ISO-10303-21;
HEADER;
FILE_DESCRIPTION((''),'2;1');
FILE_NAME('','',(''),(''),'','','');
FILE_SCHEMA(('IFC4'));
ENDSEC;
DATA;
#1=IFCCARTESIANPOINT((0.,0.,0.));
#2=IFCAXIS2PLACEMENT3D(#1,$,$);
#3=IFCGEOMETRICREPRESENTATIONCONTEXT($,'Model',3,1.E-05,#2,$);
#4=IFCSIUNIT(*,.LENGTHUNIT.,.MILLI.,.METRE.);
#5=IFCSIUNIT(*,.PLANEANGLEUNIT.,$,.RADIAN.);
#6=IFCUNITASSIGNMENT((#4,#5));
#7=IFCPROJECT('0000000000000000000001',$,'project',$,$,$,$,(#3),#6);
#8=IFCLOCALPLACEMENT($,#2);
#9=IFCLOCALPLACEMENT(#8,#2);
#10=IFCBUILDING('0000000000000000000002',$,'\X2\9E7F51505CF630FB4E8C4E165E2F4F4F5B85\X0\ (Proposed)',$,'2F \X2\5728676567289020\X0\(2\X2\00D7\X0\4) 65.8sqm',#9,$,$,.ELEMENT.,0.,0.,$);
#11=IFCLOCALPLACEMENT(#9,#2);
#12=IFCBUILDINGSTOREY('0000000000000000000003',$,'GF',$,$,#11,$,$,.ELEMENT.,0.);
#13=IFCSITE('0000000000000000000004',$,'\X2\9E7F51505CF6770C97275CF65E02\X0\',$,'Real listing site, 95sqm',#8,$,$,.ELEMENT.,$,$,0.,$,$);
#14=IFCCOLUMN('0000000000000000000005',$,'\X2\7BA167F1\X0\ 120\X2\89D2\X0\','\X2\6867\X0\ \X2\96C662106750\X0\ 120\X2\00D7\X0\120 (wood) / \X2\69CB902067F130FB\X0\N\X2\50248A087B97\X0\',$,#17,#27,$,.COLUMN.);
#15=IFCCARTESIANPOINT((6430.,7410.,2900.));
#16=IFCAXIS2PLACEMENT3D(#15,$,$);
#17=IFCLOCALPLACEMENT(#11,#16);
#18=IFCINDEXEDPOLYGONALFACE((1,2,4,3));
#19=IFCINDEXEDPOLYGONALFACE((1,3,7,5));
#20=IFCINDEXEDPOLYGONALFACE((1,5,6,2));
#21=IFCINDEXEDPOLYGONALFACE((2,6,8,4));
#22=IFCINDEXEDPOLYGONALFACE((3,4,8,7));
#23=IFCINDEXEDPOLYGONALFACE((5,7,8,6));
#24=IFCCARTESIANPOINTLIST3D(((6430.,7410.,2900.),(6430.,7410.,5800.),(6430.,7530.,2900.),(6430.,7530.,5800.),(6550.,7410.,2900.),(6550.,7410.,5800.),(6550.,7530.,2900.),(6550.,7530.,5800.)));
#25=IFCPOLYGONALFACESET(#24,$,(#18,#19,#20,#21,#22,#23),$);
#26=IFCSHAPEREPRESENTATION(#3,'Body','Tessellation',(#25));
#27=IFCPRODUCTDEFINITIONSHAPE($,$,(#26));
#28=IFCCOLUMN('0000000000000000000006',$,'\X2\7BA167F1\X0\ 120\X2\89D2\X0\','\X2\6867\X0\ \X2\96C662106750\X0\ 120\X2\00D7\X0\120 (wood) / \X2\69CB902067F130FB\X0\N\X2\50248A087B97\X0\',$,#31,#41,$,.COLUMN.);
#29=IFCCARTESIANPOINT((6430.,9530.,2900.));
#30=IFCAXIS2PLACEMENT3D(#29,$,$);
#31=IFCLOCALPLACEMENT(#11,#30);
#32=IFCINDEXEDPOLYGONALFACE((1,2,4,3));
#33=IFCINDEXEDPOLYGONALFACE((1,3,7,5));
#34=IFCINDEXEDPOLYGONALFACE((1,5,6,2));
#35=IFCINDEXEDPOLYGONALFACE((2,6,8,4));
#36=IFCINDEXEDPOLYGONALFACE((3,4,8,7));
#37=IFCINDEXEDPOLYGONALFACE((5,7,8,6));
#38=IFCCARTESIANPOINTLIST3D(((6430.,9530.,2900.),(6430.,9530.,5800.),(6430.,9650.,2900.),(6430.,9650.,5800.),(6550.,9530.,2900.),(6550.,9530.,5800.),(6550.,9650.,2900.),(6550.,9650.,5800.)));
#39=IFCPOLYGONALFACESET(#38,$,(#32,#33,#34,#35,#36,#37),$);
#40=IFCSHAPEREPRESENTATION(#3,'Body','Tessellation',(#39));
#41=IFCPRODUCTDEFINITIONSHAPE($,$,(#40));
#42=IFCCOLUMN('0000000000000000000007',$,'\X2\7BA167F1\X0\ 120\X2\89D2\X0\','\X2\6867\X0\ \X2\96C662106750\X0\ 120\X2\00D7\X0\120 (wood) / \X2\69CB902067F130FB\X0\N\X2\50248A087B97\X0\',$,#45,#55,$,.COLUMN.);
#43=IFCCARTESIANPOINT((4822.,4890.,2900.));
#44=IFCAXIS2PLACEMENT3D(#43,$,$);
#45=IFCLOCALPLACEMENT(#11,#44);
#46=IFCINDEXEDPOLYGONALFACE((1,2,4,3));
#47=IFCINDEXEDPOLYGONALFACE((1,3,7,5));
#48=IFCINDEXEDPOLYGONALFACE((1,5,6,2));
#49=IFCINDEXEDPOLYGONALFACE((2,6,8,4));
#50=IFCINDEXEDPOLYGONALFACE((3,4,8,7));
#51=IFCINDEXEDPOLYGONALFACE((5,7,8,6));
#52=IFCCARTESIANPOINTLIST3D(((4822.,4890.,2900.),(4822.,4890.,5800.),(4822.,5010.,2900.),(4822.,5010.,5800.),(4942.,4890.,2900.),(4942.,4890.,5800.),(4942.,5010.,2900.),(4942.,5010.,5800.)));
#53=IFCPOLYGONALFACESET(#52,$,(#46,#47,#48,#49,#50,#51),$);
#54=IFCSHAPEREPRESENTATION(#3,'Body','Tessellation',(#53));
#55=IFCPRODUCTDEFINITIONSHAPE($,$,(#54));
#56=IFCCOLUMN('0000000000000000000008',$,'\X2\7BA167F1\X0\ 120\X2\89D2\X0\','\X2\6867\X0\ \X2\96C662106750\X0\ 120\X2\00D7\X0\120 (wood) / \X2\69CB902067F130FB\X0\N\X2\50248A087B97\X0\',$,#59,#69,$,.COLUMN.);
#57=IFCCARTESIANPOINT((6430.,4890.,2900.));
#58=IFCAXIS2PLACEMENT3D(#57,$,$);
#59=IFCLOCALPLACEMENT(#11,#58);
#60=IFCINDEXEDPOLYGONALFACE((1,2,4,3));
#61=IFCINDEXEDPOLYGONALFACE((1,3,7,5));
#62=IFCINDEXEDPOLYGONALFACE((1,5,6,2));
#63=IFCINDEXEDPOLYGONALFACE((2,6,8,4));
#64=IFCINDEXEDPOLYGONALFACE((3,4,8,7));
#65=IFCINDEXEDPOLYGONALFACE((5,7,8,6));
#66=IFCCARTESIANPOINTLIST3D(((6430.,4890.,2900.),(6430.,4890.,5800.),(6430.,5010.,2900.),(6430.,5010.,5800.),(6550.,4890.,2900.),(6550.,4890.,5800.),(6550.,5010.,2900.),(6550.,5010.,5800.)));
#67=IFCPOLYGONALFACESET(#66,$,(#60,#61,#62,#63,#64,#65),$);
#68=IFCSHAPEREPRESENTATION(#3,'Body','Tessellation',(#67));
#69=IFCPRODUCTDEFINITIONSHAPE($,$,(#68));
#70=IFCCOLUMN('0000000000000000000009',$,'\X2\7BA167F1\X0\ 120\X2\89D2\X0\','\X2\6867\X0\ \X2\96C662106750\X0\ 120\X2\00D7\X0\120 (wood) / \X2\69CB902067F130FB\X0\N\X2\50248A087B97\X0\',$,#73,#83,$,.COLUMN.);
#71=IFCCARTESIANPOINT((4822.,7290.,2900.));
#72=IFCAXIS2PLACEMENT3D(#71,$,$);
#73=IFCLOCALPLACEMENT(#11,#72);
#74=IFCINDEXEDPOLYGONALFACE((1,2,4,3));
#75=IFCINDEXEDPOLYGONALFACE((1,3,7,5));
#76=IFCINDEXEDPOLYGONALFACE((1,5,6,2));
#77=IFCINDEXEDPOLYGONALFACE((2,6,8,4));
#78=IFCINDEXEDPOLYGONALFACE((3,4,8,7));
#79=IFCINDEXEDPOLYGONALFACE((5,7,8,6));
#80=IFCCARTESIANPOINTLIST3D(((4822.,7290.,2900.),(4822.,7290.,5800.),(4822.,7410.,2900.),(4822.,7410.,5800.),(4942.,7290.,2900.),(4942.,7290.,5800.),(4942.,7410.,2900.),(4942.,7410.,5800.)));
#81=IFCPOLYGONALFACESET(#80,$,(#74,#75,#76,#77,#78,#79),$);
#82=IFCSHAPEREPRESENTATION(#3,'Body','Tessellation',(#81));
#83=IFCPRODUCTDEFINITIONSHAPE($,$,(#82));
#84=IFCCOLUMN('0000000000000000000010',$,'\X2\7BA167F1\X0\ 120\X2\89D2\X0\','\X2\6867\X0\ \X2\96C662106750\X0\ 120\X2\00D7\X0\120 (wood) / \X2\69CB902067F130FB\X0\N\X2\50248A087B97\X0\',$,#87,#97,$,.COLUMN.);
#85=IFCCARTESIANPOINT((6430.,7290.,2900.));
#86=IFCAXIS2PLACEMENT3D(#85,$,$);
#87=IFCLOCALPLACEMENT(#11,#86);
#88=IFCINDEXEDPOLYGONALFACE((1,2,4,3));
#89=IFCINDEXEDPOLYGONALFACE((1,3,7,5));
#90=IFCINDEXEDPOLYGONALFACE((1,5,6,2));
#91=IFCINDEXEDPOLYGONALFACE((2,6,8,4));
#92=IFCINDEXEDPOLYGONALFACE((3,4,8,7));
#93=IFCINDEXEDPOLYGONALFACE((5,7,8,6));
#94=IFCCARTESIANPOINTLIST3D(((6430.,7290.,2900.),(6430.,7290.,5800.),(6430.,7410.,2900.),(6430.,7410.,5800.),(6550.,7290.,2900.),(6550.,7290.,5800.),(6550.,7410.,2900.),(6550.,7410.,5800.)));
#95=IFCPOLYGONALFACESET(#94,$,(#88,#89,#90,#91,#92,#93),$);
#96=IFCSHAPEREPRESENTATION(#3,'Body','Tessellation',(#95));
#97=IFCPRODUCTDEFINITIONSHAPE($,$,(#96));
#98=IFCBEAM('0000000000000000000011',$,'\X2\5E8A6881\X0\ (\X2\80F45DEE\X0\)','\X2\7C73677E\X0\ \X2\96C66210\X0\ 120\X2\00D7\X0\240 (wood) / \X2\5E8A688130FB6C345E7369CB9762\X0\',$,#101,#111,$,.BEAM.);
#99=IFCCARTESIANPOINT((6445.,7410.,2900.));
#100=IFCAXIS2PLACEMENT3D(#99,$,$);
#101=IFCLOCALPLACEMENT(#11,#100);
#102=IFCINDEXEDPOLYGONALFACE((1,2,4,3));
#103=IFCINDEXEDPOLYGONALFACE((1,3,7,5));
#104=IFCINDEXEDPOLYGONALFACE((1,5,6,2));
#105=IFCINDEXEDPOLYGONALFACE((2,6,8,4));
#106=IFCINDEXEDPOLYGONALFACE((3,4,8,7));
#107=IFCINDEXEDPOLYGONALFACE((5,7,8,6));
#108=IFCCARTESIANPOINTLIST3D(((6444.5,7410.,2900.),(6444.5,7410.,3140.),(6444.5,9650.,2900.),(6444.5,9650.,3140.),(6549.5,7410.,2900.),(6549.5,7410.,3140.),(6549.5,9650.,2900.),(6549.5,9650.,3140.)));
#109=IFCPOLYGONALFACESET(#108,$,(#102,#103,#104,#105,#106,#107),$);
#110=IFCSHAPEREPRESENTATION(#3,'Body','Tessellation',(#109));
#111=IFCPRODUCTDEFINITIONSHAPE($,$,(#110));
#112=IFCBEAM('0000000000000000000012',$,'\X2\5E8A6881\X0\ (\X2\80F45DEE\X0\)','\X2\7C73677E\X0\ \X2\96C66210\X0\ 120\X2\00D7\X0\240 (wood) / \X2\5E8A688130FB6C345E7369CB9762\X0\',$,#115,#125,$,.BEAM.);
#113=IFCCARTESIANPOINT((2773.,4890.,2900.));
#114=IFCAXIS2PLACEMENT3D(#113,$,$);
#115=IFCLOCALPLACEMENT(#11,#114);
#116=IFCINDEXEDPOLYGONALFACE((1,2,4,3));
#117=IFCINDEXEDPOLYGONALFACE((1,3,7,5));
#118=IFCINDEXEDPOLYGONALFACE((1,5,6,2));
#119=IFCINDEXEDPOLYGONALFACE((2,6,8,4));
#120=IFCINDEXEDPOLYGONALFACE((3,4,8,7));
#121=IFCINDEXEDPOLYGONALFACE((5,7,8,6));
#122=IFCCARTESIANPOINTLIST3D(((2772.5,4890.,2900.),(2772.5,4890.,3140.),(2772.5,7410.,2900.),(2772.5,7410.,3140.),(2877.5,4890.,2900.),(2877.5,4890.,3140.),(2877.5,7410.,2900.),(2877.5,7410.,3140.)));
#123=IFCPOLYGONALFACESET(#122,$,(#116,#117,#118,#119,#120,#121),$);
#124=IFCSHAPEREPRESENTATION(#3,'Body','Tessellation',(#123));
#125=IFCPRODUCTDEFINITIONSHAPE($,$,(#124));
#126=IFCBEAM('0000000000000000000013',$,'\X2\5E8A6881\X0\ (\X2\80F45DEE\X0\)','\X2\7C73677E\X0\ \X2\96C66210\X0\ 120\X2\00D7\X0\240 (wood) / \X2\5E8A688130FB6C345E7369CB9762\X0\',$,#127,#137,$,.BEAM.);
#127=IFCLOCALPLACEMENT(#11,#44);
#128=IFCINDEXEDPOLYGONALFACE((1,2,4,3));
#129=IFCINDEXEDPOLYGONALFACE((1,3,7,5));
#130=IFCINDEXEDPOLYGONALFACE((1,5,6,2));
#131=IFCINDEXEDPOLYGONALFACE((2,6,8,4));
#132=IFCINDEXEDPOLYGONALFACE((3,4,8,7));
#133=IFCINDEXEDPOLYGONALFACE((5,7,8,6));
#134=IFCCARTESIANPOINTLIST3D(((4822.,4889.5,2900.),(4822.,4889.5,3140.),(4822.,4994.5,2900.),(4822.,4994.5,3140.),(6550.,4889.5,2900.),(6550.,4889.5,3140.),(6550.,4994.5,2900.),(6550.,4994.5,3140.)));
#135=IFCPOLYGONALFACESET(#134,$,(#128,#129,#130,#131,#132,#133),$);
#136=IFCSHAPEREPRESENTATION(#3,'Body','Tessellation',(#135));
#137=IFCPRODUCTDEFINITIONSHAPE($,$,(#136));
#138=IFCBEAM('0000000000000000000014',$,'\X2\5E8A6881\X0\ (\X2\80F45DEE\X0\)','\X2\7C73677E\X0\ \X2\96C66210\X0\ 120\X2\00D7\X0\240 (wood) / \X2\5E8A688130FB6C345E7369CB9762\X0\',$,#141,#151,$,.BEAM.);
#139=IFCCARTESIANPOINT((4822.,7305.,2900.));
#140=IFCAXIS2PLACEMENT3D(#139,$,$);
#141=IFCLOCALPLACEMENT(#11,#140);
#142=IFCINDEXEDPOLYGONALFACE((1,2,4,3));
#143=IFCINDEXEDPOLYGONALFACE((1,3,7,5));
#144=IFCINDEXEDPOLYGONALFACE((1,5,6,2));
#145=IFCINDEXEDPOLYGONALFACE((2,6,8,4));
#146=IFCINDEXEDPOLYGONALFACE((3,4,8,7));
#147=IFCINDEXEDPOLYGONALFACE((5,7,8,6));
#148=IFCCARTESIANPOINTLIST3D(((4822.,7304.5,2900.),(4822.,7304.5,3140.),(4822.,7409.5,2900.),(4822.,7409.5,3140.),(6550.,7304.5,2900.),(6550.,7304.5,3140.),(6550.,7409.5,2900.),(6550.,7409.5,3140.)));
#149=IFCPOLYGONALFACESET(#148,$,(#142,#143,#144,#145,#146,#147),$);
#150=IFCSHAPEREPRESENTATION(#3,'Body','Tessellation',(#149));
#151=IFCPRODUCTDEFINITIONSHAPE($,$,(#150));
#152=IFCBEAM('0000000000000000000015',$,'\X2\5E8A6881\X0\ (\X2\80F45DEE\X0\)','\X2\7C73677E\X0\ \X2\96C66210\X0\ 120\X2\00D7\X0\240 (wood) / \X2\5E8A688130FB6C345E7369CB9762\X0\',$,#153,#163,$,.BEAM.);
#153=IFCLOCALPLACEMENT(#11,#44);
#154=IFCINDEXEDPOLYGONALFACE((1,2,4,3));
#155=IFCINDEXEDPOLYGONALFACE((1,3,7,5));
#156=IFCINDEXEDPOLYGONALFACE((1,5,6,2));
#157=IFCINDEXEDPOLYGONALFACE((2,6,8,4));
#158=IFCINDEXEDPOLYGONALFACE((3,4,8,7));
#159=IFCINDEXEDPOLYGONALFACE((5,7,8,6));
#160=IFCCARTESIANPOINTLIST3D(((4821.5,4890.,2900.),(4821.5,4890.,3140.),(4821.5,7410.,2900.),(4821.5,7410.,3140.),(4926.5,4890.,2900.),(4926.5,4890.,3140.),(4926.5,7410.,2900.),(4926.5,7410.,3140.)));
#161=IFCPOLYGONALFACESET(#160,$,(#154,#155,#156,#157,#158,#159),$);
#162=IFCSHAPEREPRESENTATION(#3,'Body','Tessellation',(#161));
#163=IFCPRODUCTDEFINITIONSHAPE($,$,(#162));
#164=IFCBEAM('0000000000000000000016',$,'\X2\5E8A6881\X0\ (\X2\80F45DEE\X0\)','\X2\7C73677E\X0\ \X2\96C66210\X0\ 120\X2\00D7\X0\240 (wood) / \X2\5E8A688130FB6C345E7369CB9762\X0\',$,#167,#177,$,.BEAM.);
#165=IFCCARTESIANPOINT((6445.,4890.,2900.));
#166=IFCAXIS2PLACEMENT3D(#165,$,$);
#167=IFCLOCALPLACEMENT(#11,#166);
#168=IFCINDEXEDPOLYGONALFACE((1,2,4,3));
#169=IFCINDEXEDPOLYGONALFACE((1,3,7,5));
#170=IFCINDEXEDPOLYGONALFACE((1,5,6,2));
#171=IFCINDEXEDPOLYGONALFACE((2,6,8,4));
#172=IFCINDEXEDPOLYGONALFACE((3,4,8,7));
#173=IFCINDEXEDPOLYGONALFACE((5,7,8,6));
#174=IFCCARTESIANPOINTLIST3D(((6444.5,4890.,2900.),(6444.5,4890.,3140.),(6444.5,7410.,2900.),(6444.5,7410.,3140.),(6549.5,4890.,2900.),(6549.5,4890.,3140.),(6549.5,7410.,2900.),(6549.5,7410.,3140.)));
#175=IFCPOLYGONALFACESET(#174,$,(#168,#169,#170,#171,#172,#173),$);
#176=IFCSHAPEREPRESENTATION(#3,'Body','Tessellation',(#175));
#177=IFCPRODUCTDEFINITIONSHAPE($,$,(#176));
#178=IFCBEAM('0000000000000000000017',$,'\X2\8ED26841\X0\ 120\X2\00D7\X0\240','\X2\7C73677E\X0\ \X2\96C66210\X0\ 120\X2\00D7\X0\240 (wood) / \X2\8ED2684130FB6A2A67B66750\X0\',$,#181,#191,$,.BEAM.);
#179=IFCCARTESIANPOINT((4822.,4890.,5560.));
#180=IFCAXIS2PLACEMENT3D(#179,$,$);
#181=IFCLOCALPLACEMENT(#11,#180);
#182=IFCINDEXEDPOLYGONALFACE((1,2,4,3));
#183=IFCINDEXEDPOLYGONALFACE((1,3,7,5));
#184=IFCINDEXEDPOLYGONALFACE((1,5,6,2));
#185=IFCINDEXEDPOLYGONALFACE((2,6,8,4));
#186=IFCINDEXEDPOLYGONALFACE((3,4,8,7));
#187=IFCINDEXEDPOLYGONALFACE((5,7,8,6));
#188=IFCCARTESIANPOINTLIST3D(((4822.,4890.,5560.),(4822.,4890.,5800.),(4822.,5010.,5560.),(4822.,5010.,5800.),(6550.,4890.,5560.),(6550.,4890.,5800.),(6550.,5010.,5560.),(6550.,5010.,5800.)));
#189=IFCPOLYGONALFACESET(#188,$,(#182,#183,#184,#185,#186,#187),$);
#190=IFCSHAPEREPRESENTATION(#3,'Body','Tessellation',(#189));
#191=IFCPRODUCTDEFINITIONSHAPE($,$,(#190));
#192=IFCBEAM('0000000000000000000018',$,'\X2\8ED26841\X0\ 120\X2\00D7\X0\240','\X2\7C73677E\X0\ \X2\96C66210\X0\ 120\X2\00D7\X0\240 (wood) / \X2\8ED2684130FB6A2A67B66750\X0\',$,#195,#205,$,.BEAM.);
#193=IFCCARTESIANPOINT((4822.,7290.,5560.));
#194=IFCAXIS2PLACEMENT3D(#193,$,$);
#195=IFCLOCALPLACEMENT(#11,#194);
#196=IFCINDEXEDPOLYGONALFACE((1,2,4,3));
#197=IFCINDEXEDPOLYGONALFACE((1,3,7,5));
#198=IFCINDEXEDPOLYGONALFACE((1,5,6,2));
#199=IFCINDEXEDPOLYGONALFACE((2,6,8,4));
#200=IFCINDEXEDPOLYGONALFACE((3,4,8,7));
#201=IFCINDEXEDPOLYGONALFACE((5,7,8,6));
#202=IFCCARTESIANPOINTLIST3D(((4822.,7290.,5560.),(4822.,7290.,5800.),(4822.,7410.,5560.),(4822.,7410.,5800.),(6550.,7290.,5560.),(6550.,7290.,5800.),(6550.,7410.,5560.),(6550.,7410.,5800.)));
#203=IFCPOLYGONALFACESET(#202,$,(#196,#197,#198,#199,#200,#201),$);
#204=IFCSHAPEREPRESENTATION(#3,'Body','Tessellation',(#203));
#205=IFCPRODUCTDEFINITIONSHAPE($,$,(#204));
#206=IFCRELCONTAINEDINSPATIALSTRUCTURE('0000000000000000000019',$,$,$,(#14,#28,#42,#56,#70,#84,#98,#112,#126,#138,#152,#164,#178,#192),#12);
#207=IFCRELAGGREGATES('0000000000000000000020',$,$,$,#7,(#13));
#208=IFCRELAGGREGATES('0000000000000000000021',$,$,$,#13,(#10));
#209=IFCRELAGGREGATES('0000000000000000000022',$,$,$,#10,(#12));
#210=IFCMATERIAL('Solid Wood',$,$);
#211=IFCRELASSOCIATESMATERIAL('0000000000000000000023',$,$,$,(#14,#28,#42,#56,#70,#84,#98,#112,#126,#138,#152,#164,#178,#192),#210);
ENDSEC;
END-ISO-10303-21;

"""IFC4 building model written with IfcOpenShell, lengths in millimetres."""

from ifc_helpers import new_model, si_unit, frame, frame_2d, origin, place, context, project, spatial, rectangle, extrude, material, element, save


model = new_model("IFC4")

# Units and contexts
model_context = context("Model", 3, precision=1e-05, world=origin())
ifc_project = project(units=[si_unit("LENGTHUNIT", "METRE", prefix="MILLI"), si_unit("PLANEANGLEUNIT", "RADIAN")], contexts=[model_context])

# Site, building, storey
site_placement = place(None, origin())
site = spatial("IfcSite", under=ifc_project, at=site_placement, Name="鹿児島県霧島市", ObjectType="Real listing site, 95sqm", CompositionType="ELEMENT", RefElevation=0.0)
building_placement = place(site_placement, origin())
building = spatial("IfcBuilding", under=site, at=building_placement, Name="鹿児島・二世帯住宅 (Proposed)", ObjectType="2F 在来木造(2×4) 65.8sqm", CompositionType="ELEMENT", ElevationOfRefHeight=0.0, ElevationOfTerrain=0.0)
storey_placement = place(building_placement, origin())
storey = spatial("IfcBuildingStorey", under=building, at=storey_placement, Name="GF", CompositionType="ELEMENT", Elevation=0.0)

# Columns
ifc_material_1 = material(Name="Solid Wood")
column_1_placement = place(storey_placement, frame((6430.0, 7410.0, 2900.0)))
element("IfcColumn", 1, at=column_1_placement, inside=storey, material=ifc_material_1, Name="管柱 120角", Description="桧 集成材 120×120 (wood) / 構造柱・N値計算", PredefinedType="COLUMN", context=model_context, shape_type="SweptSolid", body=[
    extrude(rectangle(XDim=120.0, YDim=120.0, at=frame_2d((60.0, 60.0))), frame((6430.0, 7410.0, 2900.0)), (0.0, 0.0, 1.0), 2900.0),
])
column_2_placement = place(storey_placement, frame((6430.0, 9530.0, 2900.0)))
element("IfcColumn", 2, at=column_2_placement, inside=storey, material=ifc_material_1, Name="管柱 120角", Description="桧 集成材 120×120 (wood) / 構造柱・N値計算", PredefinedType="COLUMN", context=model_context, shape_type="SweptSolid", body=[
    extrude(rectangle(XDim=120.0, YDim=120.0, at=frame_2d((60.0, 60.0))), frame((6430.0, 9530.0, 2900.0)), (0.0, 0.0, 1.0), 2900.0),
])
column_3_placement = place(storey_placement, frame((4822.0, 4890.0, 2900.0)))
element("IfcColumn", 3, at=column_3_placement, inside=storey, material=ifc_material_1, Name="管柱 120角", Description="桧 集成材 120×120 (wood) / 構造柱・N値計算", PredefinedType="COLUMN", context=model_context, shape_type="SweptSolid", body=[
    extrude(rectangle(XDim=120.0, YDim=120.0, at=frame_2d((60.0, 60.0))), frame((4822.0, 4890.0, 2900.0)), (0.0, 0.0, 1.0), 2900.0),
])
column_4_placement = place(storey_placement, frame((6430.0, 4890.0, 2900.0)))
element("IfcColumn", 4, at=column_4_placement, inside=storey, material=ifc_material_1, Name="管柱 120角", Description="桧 集成材 120×120 (wood) / 構造柱・N値計算", PredefinedType="COLUMN", context=model_context, shape_type="SweptSolid", body=[
    extrude(rectangle(XDim=120.0, YDim=120.0, at=frame_2d((60.0, 60.0))), frame((6430.0, 4890.0, 2900.0)), (0.0, 0.0, 1.0), 2900.0),
])
column_5_placement = place(storey_placement, frame((4822.0, 7290.0, 2900.0)))
element("IfcColumn", 5, at=column_5_placement, inside=storey, material=ifc_material_1, Name="管柱 120角", Description="桧 集成材 120×120 (wood) / 構造柱・N値計算", PredefinedType="COLUMN", context=model_context, shape_type="SweptSolid", body=[
    extrude(rectangle(XDim=120.0, YDim=120.0, at=frame_2d((60.0, 60.0))), frame((4822.0, 7290.0, 2900.0)), (0.0, 0.0, 1.0), 2900.0),
])
column_6_placement = place(storey_placement, frame((6430.0, 7290.0, 2900.0)))
element("IfcColumn", 6, at=column_6_placement, inside=storey, material=ifc_material_1, Name="管柱 120角", Description="桧 集成材 120×120 (wood) / 構造柱・N値計算", PredefinedType="COLUMN", context=model_context, shape_type="SweptSolid", body=[
    extrude(rectangle(XDim=120.0, YDim=120.0, at=frame_2d((60.0, 60.0))), frame((6430.0, 7290.0, 2900.0)), (0.0, 0.0, 1.0), 2900.0),
])

# Beams
beam_1_placement = place(storey_placement, frame((6445.0, 7410.0, 2900.0)))
element("IfcBeam", 7, at=beam_1_placement, inside=storey, material=ifc_material_1, Name="床梁 (胴差)", Description="米松 集成 120×240 (wood) / 床梁・水平構面", PredefinedType="BEAM", context=model_context, shape_type="SweptSolid", body=[
    extrude(rectangle(XDim=105.0, YDim=2240.0, at=frame_2d((52.0, 1120.0))), frame((6445.0, 7410.0, 2900.0)), (0.0, 0.0, 1.0), 240.0),
])
beam_2_placement = place(storey_placement, frame((2773.0, 4890.0, 2900.0)))
element("IfcBeam", 8, at=beam_2_placement, inside=storey, material=ifc_material_1, Name="床梁 (胴差)", Description="米松 集成 120×240 (wood) / 床梁・水平構面", PredefinedType="BEAM", context=model_context, shape_type="SweptSolid", body=[
    extrude(rectangle(XDim=105.0, YDim=2520.0, at=frame_2d((52.0, 1260.0))), frame((2773.0, 4890.0, 2900.0)), (0.0, 0.0, 1.0), 240.0),
])
beam_3_placement = place(storey_placement, frame((4822.0, 4890.0, 2900.0)))
element("IfcBeam", 9, at=beam_3_placement, inside=storey, material=ifc_material_1, Name="床梁 (胴差)", Description="米松 集成 120×240 (wood) / 床梁・水平構面", PredefinedType="BEAM", context=model_context, shape_type="SweptSolid", body=[
    extrude(rectangle(XDim=1728.0, YDim=105.0, at=frame_2d((864.0, 52.0))), frame((4822.0, 4890.0, 2900.0)), (0.0, 0.0, 1.0), 240.0),
])
beam_4_placement = place(storey_placement, frame((4822.0, 7305.0, 2900.0)))
element("IfcBeam", 10, at=beam_4_placement, inside=storey, material=ifc_material_1, Name="床梁 (胴差)", Description="米松 集成 120×240 (wood) / 床梁・水平構面", PredefinedType="BEAM", context=model_context, shape_type="SweptSolid", body=[
    extrude(rectangle(XDim=1728.0, YDim=105.0, at=frame_2d((864.0, 52.0))), frame((4822.0, 7305.0, 2900.0)), (0.0, 0.0, 1.0), 240.0),
])
beam_5_placement = place(storey_placement, frame((4822.0, 4890.0, 2900.0)))
element("IfcBeam", 11, at=beam_5_placement, inside=storey, material=ifc_material_1, Name="床梁 (胴差)", Description="米松 集成 120×240 (wood) / 床梁・水平構面", PredefinedType="BEAM", context=model_context, shape_type="SweptSolid", body=[
    extrude(rectangle(XDim=105.0, YDim=2520.0, at=frame_2d((52.0, 1260.0))), frame((4822.0, 4890.0, 2900.0)), (0.0, 0.0, 1.0), 240.0),
])
beam_6_placement = place(storey_placement, frame((6445.0, 4890.0, 2900.0)))
element("IfcBeam", 12, at=beam_6_placement, inside=storey, material=ifc_material_1, Name="床梁 (胴差)", Description="米松 集成 120×240 (wood) / 床梁・水平構面", PredefinedType="BEAM", context=model_context, shape_type="SweptSolid", body=[
    extrude(rectangle(XDim=105.0, YDim=2520.0, at=frame_2d((52.0, 1260.0))), frame((6445.0, 4890.0, 2900.0)), (0.0, 0.0, 1.0), 240.0),
])
beam_7_placement = place(storey_placement, frame((4822.0, 4890.0, 5560.0)))
element("IfcBeam", 13, at=beam_7_placement, inside=storey, material=ifc_material_1, Name="軒桁 120×240", Description="米松 集成 120×240 (wood) / 軒桁・横架材", PredefinedType="BEAM", context=model_context, shape_type="SweptSolid", body=[
    extrude(rectangle(XDim=1728.0, YDim=120.0, at=frame_2d((864.0, 60.0))), frame((4822.0, 4890.0, 5560.0)), (0.0, 0.0, 1.0), 240.0),
])
beam_8_placement = place(storey_placement, frame((4822.0, 7290.0, 5560.0)))
element("IfcBeam", 14, at=beam_8_placement, inside=storey, material=ifc_material_1, Name="軒桁 120×240", Description="米松 集成 120×240 (wood) / 軒桁・横架材", PredefinedType="BEAM", context=model_context, shape_type="SweptSolid", body=[
    extrude(rectangle(XDim=1728.0, YDim=120.0, at=frame_2d((864.0, 60.0))), frame((4822.0, 7290.0, 5560.0)), (0.0, 0.0, 1.0), 240.0),
])

save(model, "model.ifc")
